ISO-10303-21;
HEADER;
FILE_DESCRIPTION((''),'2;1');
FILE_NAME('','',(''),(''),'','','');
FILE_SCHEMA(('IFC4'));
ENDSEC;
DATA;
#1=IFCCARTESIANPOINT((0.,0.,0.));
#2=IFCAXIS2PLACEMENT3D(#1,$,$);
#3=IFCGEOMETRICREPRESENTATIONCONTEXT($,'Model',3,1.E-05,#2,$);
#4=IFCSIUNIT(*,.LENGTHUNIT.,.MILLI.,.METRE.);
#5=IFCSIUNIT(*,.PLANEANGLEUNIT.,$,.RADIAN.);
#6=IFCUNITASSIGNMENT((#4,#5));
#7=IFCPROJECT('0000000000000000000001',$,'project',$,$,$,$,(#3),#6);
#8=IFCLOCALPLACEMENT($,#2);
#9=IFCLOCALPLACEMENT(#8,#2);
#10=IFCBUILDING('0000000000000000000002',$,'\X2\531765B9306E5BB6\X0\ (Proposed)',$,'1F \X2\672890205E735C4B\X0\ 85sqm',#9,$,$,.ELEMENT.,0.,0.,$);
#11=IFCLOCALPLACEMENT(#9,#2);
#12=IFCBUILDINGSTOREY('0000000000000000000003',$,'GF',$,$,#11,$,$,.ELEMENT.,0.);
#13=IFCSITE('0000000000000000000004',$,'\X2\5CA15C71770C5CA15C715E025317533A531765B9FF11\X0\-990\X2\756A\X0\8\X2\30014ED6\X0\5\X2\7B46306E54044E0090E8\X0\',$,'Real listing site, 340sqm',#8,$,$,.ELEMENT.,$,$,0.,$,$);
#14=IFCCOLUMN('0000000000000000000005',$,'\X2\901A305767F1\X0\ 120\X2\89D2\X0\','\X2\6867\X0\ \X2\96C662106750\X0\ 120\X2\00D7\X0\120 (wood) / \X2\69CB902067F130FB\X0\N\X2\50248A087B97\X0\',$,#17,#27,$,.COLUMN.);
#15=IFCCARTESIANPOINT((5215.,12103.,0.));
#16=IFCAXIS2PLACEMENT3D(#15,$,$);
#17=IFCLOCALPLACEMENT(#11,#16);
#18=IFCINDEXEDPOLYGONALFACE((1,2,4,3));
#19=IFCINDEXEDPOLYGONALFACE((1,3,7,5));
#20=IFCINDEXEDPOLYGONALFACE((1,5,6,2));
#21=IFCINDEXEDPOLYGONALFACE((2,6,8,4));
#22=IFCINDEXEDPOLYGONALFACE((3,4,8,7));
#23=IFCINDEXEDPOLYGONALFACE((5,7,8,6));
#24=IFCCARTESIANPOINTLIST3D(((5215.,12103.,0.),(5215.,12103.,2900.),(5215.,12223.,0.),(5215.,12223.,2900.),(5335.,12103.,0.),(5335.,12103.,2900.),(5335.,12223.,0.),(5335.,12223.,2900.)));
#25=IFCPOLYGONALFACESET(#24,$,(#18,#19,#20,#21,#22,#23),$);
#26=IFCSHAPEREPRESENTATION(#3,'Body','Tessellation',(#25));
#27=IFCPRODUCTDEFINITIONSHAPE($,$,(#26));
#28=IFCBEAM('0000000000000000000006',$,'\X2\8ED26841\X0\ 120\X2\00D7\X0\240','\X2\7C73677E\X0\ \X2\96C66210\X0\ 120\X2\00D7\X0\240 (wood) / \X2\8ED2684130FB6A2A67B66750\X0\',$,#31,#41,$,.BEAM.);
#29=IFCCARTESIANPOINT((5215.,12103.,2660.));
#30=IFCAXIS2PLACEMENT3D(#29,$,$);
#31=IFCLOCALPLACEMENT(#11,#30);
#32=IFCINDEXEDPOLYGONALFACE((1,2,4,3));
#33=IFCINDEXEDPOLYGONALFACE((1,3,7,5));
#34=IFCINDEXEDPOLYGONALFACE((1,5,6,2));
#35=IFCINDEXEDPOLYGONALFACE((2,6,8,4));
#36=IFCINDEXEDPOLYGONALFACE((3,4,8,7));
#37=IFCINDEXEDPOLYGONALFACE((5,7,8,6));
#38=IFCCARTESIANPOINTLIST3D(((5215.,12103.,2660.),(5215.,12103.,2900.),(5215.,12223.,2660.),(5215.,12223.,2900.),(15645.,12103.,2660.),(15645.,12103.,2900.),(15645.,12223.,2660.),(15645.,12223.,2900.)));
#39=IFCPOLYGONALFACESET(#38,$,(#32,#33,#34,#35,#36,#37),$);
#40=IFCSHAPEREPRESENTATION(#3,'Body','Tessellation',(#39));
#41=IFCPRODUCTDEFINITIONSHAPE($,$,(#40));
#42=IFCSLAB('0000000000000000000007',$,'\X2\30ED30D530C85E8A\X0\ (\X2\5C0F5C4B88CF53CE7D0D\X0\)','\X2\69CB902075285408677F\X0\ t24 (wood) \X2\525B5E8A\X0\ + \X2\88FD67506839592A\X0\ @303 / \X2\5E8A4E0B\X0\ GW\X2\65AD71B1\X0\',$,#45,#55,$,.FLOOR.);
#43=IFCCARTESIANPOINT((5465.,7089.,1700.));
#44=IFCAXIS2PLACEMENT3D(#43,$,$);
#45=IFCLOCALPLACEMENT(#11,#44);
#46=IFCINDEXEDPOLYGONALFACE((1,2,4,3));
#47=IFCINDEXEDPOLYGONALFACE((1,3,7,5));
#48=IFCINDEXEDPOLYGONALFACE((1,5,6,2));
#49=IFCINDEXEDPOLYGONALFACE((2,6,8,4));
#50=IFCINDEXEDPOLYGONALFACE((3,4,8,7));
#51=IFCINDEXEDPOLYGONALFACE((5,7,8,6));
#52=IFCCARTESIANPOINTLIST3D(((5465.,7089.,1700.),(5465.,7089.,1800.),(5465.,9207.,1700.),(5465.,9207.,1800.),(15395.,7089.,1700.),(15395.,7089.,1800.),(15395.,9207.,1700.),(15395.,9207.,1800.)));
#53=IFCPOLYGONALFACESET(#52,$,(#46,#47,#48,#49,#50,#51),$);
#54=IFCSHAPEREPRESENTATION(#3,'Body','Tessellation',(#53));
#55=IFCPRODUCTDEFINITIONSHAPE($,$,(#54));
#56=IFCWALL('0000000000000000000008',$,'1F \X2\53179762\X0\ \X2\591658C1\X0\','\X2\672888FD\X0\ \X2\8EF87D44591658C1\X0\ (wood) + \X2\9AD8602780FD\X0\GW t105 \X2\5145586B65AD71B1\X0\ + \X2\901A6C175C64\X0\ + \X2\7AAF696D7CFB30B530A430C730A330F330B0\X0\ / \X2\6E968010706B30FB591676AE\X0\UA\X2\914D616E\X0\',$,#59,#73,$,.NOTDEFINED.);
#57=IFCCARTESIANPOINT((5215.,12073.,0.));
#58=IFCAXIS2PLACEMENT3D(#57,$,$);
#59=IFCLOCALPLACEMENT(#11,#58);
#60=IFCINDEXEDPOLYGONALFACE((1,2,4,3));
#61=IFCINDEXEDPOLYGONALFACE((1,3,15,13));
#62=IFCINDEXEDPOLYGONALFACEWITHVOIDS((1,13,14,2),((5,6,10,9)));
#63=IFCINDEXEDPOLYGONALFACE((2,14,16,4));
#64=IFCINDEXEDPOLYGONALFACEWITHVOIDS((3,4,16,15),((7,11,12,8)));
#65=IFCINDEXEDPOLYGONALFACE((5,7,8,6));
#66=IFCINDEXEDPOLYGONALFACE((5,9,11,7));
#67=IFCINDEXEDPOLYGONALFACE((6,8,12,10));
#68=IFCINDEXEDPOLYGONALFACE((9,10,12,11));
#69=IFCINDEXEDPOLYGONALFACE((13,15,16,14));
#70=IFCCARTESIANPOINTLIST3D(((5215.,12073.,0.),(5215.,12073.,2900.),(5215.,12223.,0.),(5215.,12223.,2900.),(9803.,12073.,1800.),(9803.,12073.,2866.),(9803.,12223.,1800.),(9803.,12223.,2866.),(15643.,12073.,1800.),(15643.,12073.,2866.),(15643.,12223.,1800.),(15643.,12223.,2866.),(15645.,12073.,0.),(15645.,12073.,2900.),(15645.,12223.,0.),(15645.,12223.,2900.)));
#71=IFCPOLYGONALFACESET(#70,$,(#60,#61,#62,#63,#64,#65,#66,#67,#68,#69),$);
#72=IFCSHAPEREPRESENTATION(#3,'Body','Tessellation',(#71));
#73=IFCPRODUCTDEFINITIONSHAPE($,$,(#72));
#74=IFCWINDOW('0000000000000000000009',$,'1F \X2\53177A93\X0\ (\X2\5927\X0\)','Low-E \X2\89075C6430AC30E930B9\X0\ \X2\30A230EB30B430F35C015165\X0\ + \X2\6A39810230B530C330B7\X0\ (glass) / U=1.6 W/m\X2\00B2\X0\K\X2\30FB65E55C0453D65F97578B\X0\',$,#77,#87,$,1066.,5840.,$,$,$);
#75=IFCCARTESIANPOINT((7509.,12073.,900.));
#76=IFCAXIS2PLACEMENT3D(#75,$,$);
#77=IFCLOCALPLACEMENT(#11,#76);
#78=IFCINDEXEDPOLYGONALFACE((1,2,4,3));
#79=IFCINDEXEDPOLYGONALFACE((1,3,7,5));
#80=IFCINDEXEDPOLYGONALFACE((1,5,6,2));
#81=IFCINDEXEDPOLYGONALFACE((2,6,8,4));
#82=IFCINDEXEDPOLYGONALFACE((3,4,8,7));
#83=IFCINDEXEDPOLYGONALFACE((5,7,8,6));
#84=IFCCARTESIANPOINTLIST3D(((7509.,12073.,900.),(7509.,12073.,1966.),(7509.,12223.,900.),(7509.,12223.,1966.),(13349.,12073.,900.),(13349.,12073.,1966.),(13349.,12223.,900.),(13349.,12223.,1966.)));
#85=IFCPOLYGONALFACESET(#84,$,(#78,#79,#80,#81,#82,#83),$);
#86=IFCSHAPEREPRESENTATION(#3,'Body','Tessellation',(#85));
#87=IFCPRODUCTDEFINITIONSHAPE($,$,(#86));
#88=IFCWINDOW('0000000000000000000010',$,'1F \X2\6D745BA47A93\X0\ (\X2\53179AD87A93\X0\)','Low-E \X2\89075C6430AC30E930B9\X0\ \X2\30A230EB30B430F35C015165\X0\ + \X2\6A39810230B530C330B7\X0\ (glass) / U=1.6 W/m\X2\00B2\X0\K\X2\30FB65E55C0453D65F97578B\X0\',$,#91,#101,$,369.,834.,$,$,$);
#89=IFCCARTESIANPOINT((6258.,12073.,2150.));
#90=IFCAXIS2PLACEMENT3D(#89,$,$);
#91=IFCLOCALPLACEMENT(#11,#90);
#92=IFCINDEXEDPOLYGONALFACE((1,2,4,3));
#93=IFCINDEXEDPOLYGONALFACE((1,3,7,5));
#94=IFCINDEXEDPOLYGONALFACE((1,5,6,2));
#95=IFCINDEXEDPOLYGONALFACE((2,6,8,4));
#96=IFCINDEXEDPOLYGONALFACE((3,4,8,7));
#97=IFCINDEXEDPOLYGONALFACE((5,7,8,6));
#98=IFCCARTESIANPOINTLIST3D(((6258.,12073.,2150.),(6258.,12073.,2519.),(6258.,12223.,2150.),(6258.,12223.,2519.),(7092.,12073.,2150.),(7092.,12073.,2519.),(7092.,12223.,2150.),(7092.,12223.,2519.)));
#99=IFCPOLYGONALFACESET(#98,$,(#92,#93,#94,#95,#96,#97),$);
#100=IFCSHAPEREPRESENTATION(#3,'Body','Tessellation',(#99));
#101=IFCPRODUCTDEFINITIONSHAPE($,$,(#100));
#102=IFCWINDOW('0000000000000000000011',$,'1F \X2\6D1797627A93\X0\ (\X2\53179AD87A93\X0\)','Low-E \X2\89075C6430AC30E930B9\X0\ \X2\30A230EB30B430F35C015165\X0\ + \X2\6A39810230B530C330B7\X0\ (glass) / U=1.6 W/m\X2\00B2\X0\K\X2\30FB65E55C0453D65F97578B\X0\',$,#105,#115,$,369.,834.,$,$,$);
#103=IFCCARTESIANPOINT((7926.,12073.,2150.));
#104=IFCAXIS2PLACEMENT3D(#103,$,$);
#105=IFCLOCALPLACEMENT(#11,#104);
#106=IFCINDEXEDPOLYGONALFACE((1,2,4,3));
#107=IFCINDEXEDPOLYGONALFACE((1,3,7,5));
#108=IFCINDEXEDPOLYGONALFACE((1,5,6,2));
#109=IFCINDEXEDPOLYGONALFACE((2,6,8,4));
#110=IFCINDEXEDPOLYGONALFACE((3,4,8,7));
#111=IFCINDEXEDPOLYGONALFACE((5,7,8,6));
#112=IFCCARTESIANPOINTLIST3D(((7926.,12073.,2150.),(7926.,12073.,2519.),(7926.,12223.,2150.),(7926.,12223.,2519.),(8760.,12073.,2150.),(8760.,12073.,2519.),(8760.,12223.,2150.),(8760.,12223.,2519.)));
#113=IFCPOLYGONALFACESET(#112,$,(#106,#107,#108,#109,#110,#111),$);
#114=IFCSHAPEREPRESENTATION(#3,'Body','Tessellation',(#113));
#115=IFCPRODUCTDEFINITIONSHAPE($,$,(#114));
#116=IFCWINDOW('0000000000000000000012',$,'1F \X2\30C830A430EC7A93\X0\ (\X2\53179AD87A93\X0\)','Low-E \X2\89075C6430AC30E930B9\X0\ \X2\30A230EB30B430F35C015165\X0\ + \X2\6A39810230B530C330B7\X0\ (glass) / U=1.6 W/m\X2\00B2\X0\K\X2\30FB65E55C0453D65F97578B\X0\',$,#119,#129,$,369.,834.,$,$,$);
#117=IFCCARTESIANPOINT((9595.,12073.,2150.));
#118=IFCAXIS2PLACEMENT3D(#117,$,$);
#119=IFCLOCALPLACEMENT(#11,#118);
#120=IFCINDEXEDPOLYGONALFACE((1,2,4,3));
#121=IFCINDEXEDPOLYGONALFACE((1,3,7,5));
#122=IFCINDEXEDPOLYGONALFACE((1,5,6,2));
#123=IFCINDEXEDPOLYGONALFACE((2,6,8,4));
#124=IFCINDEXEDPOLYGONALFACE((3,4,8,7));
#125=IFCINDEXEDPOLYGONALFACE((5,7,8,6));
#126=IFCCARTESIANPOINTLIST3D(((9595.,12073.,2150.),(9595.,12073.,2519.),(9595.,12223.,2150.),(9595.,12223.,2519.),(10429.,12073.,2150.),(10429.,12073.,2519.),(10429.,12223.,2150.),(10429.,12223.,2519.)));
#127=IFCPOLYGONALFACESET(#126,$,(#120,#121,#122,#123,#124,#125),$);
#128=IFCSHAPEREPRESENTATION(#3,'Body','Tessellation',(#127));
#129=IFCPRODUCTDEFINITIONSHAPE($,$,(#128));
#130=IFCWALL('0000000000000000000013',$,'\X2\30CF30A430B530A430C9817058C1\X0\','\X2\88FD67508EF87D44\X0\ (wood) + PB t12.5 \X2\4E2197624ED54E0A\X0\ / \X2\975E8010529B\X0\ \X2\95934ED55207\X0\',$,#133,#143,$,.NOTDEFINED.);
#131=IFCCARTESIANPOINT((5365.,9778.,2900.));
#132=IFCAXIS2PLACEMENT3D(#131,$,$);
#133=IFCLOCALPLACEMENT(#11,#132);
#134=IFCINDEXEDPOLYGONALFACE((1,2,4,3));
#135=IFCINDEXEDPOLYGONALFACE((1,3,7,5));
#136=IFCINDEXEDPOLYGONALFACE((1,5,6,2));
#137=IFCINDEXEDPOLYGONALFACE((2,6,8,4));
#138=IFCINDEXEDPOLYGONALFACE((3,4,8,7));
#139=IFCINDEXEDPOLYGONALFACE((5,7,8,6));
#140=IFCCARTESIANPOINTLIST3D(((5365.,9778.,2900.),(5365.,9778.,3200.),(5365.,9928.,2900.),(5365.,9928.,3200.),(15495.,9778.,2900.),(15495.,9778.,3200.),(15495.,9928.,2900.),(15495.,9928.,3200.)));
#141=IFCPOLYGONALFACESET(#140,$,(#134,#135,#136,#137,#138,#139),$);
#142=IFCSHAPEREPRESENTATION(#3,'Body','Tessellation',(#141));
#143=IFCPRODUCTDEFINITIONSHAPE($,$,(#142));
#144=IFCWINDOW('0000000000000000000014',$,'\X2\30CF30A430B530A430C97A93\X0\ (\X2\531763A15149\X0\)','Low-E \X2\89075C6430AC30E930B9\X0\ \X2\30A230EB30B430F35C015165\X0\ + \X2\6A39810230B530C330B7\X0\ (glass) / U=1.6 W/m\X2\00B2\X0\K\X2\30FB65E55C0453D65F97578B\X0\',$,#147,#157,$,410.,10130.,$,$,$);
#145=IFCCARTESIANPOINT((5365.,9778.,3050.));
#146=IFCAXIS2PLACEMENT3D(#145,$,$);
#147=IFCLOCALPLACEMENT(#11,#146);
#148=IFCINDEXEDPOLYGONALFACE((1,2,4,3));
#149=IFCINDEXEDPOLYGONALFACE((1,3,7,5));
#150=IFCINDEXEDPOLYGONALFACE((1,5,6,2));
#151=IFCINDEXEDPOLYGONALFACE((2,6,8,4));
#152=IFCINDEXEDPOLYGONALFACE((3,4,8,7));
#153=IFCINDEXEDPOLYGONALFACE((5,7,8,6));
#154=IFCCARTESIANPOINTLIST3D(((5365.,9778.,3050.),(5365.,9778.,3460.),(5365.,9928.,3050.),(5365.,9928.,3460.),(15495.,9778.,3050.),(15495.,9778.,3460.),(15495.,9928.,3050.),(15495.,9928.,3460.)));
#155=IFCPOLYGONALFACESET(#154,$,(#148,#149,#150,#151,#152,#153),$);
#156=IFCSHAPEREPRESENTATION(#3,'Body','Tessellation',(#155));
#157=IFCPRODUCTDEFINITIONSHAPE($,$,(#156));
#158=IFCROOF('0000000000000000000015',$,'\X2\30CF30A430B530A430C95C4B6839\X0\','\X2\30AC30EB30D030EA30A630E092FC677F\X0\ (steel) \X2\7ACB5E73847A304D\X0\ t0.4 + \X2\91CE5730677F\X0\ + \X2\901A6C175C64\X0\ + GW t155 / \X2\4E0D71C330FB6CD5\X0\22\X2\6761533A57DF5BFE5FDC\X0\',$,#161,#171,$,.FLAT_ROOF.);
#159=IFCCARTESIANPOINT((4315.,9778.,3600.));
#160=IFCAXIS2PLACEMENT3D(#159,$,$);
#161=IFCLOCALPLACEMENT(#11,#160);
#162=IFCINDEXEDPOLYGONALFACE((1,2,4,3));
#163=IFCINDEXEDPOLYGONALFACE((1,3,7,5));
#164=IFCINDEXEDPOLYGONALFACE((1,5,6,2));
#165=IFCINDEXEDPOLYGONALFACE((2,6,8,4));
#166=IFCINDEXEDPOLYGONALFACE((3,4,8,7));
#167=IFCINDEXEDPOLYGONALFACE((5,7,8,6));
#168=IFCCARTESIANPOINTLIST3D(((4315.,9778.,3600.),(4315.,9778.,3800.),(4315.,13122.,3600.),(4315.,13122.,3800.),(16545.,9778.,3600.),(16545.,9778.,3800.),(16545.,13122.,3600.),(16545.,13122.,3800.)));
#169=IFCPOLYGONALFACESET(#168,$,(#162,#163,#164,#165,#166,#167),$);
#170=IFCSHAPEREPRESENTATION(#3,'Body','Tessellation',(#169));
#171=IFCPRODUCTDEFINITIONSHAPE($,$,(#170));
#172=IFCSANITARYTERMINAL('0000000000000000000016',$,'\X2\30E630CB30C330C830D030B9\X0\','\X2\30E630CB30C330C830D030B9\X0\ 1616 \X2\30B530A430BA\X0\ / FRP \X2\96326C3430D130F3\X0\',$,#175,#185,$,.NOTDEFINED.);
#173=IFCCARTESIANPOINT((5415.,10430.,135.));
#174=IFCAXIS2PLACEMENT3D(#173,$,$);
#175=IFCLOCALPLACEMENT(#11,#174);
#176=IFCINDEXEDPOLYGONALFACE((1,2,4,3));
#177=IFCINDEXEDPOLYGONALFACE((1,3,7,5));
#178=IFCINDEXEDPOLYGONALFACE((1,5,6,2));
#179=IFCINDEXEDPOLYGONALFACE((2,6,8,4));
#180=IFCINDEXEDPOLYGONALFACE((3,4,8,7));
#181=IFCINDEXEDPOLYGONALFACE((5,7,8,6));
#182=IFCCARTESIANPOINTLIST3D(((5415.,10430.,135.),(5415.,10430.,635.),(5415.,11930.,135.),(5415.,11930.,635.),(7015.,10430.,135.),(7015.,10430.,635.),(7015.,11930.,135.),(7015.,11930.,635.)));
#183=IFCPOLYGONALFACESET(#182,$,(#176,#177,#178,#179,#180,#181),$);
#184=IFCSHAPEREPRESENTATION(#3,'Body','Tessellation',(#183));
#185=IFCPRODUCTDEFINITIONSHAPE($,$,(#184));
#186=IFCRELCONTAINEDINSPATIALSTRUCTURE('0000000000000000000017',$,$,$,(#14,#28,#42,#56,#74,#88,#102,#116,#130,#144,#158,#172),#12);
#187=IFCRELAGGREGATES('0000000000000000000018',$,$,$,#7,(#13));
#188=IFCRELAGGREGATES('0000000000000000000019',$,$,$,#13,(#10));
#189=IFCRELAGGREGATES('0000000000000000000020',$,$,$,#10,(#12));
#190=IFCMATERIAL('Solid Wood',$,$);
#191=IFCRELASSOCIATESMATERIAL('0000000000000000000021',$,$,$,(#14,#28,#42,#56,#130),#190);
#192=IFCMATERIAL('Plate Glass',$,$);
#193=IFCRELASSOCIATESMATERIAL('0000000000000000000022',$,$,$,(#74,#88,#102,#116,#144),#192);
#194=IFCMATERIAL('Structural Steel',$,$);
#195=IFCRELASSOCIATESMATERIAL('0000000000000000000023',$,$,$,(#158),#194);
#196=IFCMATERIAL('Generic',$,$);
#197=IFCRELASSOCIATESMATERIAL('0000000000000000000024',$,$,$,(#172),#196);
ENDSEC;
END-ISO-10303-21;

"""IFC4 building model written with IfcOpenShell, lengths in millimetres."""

from ifc_helpers import new_model, si_unit, frame, frame_2d, origin, place, context, project, spatial, rectangle, extrude, material, element, fill, save


model = new_model("IFC4")

# Units and contexts
model_context = context("Model", 3, precision=1e-05, world=origin())
ifc_project = project(units=[si_unit("LENGTHUNIT", "METRE", prefix="MILLI"), si_unit("PLANEANGLEUNIT", "RADIAN")], contexts=[model_context])

# Site, building, storey
site_placement = place(None, origin())
site = spatial("IfcSite", under=ifc_project, at=site_placement, Name="岡山県岡山市北区北方１-990番8、他5筆の各一部", ObjectType="Real listing site, 340sqm", CompositionType="ELEMENT", RefElevation=0.0)
building_placement = place(site_placement, origin())
building = spatial("IfcBuilding", under=site, at=building_placement, Name="北方の家 (Proposed)", ObjectType="1F 木造平屋 85sqm", CompositionType="ELEMENT", ElevationOfRefHeight=0.0, ElevationOfTerrain=0.0)
storey_placement = place(building_placement, origin())
storey = spatial("IfcBuildingStorey", under=building, at=storey_placement, Name="GF", CompositionType="ELEMENT", Elevation=0.0)

# Column
ifc_material_1 = material(Name="Solid Wood")
column_1_placement = place(storey_placement, frame((5215.0, 12103.0, 0.0)))
element("IfcColumn", 1, at=column_1_placement, inside=storey, material=ifc_material_1, Name="通し柱 120角", Description="桧 集成材 120×120 (wood) / 構造柱・N値計算", PredefinedType="COLUMN", context=model_context, shape_type="SweptSolid", body=[
    extrude(rectangle(XDim=120.0, YDim=120.0, at=frame_2d((60.0, 60.0))), frame((5215.0, 12103.0, 0.0)), (0.0, 0.0, 1.0), 2900.0),
])

# Beam
beam_1_placement = place(storey_placement, frame((5215.0, 12103.0, 2660.0)))
element("IfcBeam", 2, at=beam_1_placement, inside=storey, material=ifc_material_1, Name="軒桁 120×240", Description="米松 集成 120×240 (wood) / 軒桁・横架材", PredefinedType="BEAM", context=model_context, shape_type="SweptSolid", body=[
    extrude(rectangle(XDim=10430.0, YDim=120.0, at=frame_2d((5215.0, 60.0))), frame((5215.0, 12103.0, 2660.0)), (0.0, 0.0, 1.0), 240.0),
])

# Slab
slab_placement = place(storey_placement, frame((5465.0, 7089.0, 1700.0)))
element("IfcSlab", 3, at=slab_placement, inside=storey, material=ifc_material_1, Name="ロフト床 (小屋裏収納)", Description="構造用合板 t24 (wood) 剛床 + 製材根太 @303 / 床下 GW断熱", PredefinedType="FLOOR", context=model_context, shape_type="SweptSolid", body=[
    extrude(rectangle(XDim=9930.0, YDim=2118.0, at=frame_2d((4965.0, 1059.0))), frame((5465.0, 7089.0, 1700.0)), (0.0, 0.0, 1.0), 100.0),
])

# Wall, openings, windows
wall_1_placement = place(storey_placement, frame((5215.0, 12073.0, 0.0)))
wall_1 = element("IfcWall", 4, at=wall_1_placement, inside=storey, material=ifc_material_1, Name="1F 北面 外壁", Description="木製 軸組外壁 (wood) + 高性能GW t105 充填断熱 + 通気層 + 窯業系サイディング / 準耐火・外皮UA配慮", PredefinedType="NOTDEFINED", context=model_context, shape_type="SweptSolid", body=[
    extrude(rectangle(XDim=10430.0, YDim=150.0, at=frame_2d((5215.0, 75.0))), frame((5215.0, 12073.0, 0.0)), (0.0, 0.0, 1.0), 2900.0),
])
opening_1_placement = place(storey_placement, frame((7509.0, 12073.0, 900.0)))
opening_1 = element("IfcOpeningElement", 5, at=opening_1_placement, cuts=wall_1, PredefinedType="NOTDEFINED", context=model_context, shape_type="SweptSolid", body=[
    extrude(rectangle(XDim=5840.0, YDim=150.0, at=frame_2d((2920.0, 75.0))), frame((7509.0, 12073.0, 900.0)), (0.0, 0.0, 1.0), 1066.0),
])
opening_2_placement = place(storey_placement, frame((6258.0, 12073.0, 2150.0)))
opening_2 = element("IfcOpeningElement", 6, at=opening_2_placement, cuts=wall_1, PredefinedType="NOTDEFINED", context=model_context, shape_type="SweptSolid", body=[
    extrude(rectangle(XDim=834.0, YDim=150.0, at=frame_2d((417.0, 75.0))), frame((6258.0, 12073.0, 2150.0)), (0.0, 0.0, 1.0), 369.0),
])
opening_3_placement = place(storey_placement, frame((7926.0, 12073.0, 2150.0)))
opening_3 = element("IfcOpeningElement", 7, at=opening_3_placement, cuts=wall_1, PredefinedType="NOTDEFINED", context=model_context, shape_type="SweptSolid", body=[
    extrude(rectangle(XDim=834.0, YDim=150.0, at=frame_2d((417.0, 75.0))), frame((7926.0, 12073.0, 2150.0)), (0.0, 0.0, 1.0), 369.0),
])
opening_4_placement = place(storey_placement, frame((9595.0, 12073.0, 2150.0)))
opening_4 = element("IfcOpeningElement", 8, at=opening_4_placement, cuts=wall_1, PredefinedType="NOTDEFINED", context=model_context, shape_type="SweptSolid", body=[
    extrude(rectangle(XDim=834.0, YDim=150.0, at=frame_2d((417.0, 75.0))), frame((9595.0, 12073.0, 2150.0)), (0.0, 0.0, 1.0), 369.0),
])
ifc_material_2 = material(Name="Plate Glass")
window_1_placement = place(storey_placement, frame((7509.0, 12073.0, 900.0)))
window_1 = element("IfcWindow", 9, at=window_1_placement, inside=storey, material=ifc_material_2, Name="1F 北窓 (大)", Description="Low-E 複層ガラス アルゴン封入 + 樹脂サッシ (glass) / U=1.6 W/m²K・日射取得型", OverallHeight=1066.0, OverallWidth=5840.0, context=model_context, shape_type="SweptSolid", body=[
    extrude(rectangle(XDim=5840.0, YDim=150.0, at=frame_2d((2920.0, 75.0))), frame((7509.0, 12073.0, 900.0)), (0.0, 0.0, 1.0), 1066.0),
])
fill(opening_1, window_1)
window_2_placement = place(storey_placement, frame((6258.0, 12073.0, 2150.0)))
window_2 = element("IfcWindow", 10, at=window_2_placement, inside=storey, material=ifc_material_2, Name="1F 浴室窓 (北高窓)", Description="Low-E 複層ガラス アルゴン封入 + 樹脂サッシ (glass) / U=1.6 W/m²K・日射取得型", OverallHeight=369.0, OverallWidth=834.0, context=model_context, shape_type="SweptSolid", body=[
    extrude(rectangle(XDim=834.0, YDim=150.0, at=frame_2d((417.0, 75.0))), frame((6258.0, 12073.0, 2150.0)), (0.0, 0.0, 1.0), 369.0),
])
fill(opening_2, window_2)
window_3_placement = place(storey_placement, frame((7926.0, 12073.0, 2150.0)))
window_3 = element("IfcWindow", 11, at=window_3_placement, inside=storey, material=ifc_material_2, Name="1F 洗面窓 (北高窓)", Description="Low-E 複層ガラス アルゴン封入 + 樹脂サッシ (glass) / U=1.6 W/m²K・日射取得型", OverallHeight=369.0, OverallWidth=834.0, context=model_context, shape_type="SweptSolid", body=[
    extrude(rectangle(XDim=834.0, YDim=150.0, at=frame_2d((417.0, 75.0))), frame((7926.0, 12073.0, 2150.0)), (0.0, 0.0, 1.0), 369.0),
])
fill(opening_3, window_3)
window_4_placement = place(storey_placement, frame((9595.0, 12073.0, 2150.0)))
window_4 = element("IfcWindow", 12, at=window_4_placement, inside=storey, material=ifc_material_2, Name="1F トイレ窓 (北高窓)", Description="Low-E 複層ガラス アルゴン封入 + 樹脂サッシ (glass) / U=1.6 W/m²K・日射取得型", OverallHeight=369.0, OverallWidth=834.0, context=model_context, shape_type="SweptSolid", body=[
    extrude(rectangle(XDim=834.0, YDim=150.0, at=frame_2d((417.0, 75.0))), frame((9595.0, 12073.0, 2150.0)), (0.0, 0.0, 1.0), 369.0),
])
fill(opening_4, window_4)

# Wall, opening, window
wall_2_placement = place(storey_placement, frame((5365.0, 9778.0, 2900.0)))
wall_2 = element("IfcWall", 13, at=wall_2_placement, inside=storey, material=ifc_material_1, Name="ハイサイド腰壁", Description="製材軸組 (wood) + PB t12.5 両面仕上 / 非耐力 間仕切", PredefinedType="NOTDEFINED", context=model_context, shape_type="SweptSolid", body=[
    extrude(rectangle(XDim=10130.0, YDim=150.0, at=frame_2d((5065.0, 75.0))), frame((5365.0, 9778.0, 2900.0)), (0.0, 0.0, 1.0), 700.0),
])
opening_5_placement = place(storey_placement, frame((5365.0, 9778.0, 3050.0)))
opening_5 = element("IfcOpeningElement", 14, at=opening_5_placement, cuts=wall_2, PredefinedType="NOTDEFINED", context=model_context, shape_type="SweptSolid", body=[
    extrude(rectangle(XDim=10130.0, YDim=150.0, at=frame_2d((5065.0, 75.0))), frame((5365.0, 9778.0, 3050.0)), (0.0, 0.0, 1.0), 410.0),
])
window_5_placement = place(storey_placement, frame((5365.0, 9778.0, 3050.0)))
window_5 = element("IfcWindow", 15, at=window_5_placement, inside=storey, material=ifc_material_2, Name="ハイサイド窓 (北採光)", Description="Low-E 複層ガラス アルゴン封入 + 樹脂サッシ (glass) / U=1.6 W/m²K・日射取得型", OverallHeight=410.0, OverallWidth=10130.0, context=model_context, shape_type="SweptSolid", body=[
    extrude(rectangle(XDim=10130.0, YDim=150.0, at=frame_2d((5065.0, 75.0))), frame((5365.0, 9778.0, 3050.0)), (0.0, 0.0, 1.0), 410.0),
])
fill(opening_5, window_5)

# Roof
ifc_material_3 = material(Name="Structural Steel")
roof_placement = place(storey_placement, frame((4315.0, 9778.0, 3600.0)))
element("IfcRoof", 16, at=roof_placement, inside=storey, material=ifc_material_3, Name="ハイサイド屋根", Description="ガルバリウム鋼板 (steel) 立平葺き t0.4 + 野地板 + 通気層 + GW t155 / 不燃・法22条区域対応", PredefinedType="FLAT_ROOF", context=model_context, shape_type="SweptSolid", body=[
    extrude(rectangle(XDim=12230.0, YDim=3344.0, at=frame_2d((6115.0, 1672.0))), frame((4315.0, 9778.0, 3600.0)), (0.0, 0.0, 1.0), 200.0),
])

# Sanitary terminal
ifc_material_4 = material(Name="Generic")
sanitary_terminal_placement = place(storey_placement, frame((5415.0, 10430.0, 135.0)))
element("IfcSanitaryTerminal", 17, at=sanitary_terminal_placement, inside=storey, material=ifc_material_4, Name="ユニットバス", Description="ユニットバス 1616 サイズ / FRP 防水パン", PredefinedType="NOTDEFINED", context=model_context, shape_type="SweptSolid", body=[
    extrude(rectangle(XDim=1600.0, YDim=1500.0, at=frame_2d((800.0, 750.0))), frame((5415.0, 10430.0, 135.0)), (0.0, 0.0, 1.0), 500.0),
])

save(model, "model.ifc")
